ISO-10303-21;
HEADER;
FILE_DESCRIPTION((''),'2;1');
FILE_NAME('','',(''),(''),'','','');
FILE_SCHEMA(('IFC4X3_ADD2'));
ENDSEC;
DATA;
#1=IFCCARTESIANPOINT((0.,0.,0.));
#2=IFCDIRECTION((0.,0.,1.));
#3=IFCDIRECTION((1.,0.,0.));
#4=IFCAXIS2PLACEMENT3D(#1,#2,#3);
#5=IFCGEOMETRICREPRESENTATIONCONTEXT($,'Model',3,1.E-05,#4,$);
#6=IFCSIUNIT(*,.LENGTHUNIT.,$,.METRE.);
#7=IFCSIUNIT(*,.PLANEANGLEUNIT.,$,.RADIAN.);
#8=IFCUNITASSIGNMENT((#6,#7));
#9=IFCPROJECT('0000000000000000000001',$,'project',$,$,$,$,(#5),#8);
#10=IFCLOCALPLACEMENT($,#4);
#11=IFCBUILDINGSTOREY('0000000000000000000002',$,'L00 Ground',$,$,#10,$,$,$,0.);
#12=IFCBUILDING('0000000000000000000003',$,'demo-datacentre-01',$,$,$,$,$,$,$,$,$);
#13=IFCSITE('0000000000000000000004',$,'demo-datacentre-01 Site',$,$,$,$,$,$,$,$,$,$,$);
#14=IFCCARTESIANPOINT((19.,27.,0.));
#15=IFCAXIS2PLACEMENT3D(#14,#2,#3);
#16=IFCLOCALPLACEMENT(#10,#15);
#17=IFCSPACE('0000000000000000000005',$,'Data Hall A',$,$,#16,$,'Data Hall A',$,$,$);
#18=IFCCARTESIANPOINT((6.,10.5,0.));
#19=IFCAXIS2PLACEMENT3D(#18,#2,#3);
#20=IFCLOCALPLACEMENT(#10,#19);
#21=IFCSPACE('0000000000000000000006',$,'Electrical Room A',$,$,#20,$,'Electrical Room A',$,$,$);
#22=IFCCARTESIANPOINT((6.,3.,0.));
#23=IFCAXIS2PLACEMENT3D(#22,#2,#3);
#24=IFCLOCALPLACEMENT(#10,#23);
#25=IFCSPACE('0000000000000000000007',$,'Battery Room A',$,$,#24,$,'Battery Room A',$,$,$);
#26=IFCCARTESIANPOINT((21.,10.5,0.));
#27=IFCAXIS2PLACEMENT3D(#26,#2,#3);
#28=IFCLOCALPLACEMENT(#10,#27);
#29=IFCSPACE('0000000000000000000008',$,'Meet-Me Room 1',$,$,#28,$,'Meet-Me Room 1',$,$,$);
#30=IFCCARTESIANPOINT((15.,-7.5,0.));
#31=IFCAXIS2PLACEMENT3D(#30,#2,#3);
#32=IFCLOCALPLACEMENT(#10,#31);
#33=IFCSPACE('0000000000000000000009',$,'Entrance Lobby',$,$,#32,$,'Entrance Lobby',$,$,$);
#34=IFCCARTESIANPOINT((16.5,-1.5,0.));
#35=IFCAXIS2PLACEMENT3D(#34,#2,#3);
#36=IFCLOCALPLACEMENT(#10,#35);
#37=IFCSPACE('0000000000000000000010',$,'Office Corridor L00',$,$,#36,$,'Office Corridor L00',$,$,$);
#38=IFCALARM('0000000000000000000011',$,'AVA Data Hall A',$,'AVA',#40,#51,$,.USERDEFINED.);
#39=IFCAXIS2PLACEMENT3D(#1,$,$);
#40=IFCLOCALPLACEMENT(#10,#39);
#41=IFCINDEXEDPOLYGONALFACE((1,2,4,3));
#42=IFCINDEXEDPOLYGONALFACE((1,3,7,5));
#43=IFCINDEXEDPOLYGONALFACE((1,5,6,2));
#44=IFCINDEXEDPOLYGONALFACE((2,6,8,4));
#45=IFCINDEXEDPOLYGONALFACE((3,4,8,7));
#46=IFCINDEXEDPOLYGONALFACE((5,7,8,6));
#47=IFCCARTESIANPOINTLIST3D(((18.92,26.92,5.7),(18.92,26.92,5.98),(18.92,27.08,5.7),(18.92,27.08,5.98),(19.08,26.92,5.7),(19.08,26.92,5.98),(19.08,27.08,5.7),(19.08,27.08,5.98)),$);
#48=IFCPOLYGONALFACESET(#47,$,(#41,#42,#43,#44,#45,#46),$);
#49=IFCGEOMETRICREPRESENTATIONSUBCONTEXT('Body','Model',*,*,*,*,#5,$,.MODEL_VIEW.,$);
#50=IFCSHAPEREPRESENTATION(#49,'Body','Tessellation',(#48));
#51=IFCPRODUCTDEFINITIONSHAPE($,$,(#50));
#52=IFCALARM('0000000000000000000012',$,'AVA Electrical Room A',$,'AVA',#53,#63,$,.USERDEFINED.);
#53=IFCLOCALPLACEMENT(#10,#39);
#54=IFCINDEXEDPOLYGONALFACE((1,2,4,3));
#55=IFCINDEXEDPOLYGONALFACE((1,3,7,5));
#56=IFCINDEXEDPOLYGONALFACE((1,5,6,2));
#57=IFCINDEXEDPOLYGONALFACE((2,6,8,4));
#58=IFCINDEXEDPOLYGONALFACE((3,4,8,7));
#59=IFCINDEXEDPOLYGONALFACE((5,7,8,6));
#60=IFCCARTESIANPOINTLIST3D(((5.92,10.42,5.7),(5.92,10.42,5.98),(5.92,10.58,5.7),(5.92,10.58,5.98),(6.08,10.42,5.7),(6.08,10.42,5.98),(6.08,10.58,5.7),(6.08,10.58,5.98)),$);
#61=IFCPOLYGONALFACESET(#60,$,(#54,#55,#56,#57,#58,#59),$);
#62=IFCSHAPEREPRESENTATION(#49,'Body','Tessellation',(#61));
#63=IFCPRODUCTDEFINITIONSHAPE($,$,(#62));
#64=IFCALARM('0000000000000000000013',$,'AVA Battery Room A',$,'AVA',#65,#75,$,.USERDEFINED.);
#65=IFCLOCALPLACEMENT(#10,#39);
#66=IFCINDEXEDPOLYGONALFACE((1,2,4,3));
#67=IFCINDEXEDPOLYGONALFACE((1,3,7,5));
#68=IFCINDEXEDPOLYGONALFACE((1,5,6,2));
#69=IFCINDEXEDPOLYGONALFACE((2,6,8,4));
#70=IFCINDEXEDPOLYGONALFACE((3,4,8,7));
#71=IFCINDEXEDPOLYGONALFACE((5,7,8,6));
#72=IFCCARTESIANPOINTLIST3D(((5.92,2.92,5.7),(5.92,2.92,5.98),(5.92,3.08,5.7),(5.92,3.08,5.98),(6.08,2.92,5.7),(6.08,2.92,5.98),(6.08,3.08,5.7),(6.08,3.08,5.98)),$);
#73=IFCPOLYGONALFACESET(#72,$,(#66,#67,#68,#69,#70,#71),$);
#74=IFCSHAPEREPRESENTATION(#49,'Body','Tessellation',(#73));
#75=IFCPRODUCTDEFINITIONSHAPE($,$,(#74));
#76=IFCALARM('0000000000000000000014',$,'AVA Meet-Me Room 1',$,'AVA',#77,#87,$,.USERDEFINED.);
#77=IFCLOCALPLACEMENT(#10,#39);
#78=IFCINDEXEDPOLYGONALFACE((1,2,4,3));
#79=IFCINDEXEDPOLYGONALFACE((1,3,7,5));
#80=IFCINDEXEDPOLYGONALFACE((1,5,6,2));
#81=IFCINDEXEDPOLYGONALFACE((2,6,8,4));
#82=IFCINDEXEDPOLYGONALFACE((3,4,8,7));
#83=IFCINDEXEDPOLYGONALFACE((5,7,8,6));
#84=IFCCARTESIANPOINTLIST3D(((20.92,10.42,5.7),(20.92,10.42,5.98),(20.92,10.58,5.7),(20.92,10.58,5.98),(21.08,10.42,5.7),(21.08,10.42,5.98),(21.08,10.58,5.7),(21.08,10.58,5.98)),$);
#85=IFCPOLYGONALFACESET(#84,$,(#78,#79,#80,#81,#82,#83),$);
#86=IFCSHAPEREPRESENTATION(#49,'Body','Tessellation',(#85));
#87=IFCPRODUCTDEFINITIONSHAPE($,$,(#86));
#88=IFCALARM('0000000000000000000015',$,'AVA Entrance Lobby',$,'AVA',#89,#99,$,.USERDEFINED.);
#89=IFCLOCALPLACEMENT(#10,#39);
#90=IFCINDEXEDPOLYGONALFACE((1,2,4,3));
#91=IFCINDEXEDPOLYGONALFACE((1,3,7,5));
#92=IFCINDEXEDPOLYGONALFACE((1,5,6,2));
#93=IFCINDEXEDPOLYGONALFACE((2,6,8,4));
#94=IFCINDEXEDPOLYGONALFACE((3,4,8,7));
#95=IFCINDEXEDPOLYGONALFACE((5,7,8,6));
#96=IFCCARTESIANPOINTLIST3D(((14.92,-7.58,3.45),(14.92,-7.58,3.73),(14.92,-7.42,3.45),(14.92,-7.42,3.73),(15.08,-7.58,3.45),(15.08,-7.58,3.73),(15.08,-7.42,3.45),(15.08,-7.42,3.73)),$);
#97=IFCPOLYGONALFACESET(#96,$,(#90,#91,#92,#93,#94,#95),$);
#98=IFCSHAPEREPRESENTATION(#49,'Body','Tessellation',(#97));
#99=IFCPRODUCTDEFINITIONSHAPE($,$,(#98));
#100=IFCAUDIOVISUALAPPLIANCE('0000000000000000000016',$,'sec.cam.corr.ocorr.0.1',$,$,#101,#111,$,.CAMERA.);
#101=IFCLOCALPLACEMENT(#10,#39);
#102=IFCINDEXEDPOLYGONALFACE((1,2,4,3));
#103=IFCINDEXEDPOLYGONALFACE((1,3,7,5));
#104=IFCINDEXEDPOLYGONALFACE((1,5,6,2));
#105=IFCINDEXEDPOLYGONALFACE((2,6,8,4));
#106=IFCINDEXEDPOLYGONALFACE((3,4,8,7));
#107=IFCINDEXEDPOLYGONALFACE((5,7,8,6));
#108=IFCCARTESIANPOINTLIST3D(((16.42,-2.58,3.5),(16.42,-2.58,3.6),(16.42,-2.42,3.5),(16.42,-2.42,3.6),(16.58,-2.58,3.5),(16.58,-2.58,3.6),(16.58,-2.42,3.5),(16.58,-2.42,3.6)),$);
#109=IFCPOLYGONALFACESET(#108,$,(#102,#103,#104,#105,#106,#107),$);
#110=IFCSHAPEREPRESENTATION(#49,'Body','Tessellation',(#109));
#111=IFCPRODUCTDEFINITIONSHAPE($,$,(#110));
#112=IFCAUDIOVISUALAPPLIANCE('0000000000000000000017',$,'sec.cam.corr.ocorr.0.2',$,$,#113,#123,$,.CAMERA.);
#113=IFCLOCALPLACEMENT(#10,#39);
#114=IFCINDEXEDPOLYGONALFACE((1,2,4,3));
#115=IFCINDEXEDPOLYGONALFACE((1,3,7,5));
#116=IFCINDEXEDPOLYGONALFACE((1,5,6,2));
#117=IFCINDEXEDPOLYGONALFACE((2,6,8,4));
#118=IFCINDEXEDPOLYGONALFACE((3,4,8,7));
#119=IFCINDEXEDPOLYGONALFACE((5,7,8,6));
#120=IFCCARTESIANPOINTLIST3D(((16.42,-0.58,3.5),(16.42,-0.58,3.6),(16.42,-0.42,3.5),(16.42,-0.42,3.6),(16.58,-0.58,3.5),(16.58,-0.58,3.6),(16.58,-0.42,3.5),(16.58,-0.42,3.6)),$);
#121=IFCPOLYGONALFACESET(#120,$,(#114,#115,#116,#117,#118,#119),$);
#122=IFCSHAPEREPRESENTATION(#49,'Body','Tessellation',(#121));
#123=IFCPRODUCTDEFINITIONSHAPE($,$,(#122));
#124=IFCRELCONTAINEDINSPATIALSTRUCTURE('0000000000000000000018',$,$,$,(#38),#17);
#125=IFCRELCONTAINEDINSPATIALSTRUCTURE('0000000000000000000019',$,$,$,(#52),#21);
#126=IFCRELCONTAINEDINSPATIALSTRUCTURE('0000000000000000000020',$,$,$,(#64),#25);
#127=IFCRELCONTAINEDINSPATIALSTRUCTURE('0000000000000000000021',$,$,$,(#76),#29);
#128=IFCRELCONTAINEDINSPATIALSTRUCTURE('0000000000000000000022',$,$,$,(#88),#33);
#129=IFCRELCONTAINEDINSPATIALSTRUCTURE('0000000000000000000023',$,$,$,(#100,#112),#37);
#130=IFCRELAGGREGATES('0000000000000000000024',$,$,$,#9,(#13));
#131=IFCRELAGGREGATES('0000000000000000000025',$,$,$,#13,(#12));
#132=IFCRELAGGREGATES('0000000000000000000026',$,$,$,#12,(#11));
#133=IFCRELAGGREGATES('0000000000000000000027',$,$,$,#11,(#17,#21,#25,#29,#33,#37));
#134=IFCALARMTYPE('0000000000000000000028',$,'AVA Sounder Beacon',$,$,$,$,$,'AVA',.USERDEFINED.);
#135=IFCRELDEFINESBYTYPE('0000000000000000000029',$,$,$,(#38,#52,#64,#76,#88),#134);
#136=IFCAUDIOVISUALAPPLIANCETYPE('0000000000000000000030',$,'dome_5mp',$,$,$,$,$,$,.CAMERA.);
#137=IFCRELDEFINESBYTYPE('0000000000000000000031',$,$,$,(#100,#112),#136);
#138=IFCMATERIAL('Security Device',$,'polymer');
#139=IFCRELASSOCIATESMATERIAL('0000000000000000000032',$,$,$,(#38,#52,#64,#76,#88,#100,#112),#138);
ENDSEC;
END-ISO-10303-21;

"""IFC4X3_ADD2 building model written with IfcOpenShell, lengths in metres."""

from ifc_helpers import new_model, si_unit, frame, origin_with_axes, place, context, subcontext, project, spatial, rectangle, extrude, source, transform, mapped, material, type_object, type_shapes, element, save


model = new_model("IFC4X3_ADD2")

# Units and contexts
model_context = context("Model", 3, precision=1e-05, world=origin_with_axes())
body_context = subcontext(model_context, "Body", "Model", "MODEL_VIEW")
ifc_project = project(units=[si_unit("LENGTHUNIT", "METRE"), si_unit("PLANEANGLEUNIT", "RADIAN")], contexts=[model_context])

# Site, building, storey, space
site = spatial("IfcSite", under=ifc_project, Name="demo-datacentre-01 Site")
building = spatial("IfcBuilding", under=site, Name="demo-datacentre-01")
storey_placement = place(None, origin_with_axes())
storey = spatial("IfcBuildingStorey", under=building, at=storey_placement, Name="L00 Ground", Elevation=0.0)
space_1_placement = place(storey_placement, frame((19.0, 27.0, 0.0), z_axis=(0.0, 0.0, 1.0), x_axis=(1.0, 0.0, 0.0)))
space_1 = spatial("IfcSpace", under=storey, at=space_1_placement, Name="Data Hall A", LongName="Data Hall A")

# Alarm
ifc_material = material(Name="Security Device", Category="polymer")
alarm_type = type_object("IfcAlarmType", Name="AVA Sounder Beacon", ElementType="AVA", PredefinedType="USERDEFINED")
alarm_1_placement = place(space_1_placement, frame((0.0, 0.0, 5.7), z_axis=(0.0, 0.0, 1.0), x_axis=(1.0, 0.0, 0.0)))
element("IfcAlarm", 1, at=alarm_1_placement, inside=space_1, type_object=alarm_type, material=ifc_material, Name="AVA Data Hall A", ObjectType="AVA", PredefinedType="USERDEFINED", context=body_context, shape_type="SweptSolid", body=[
    extrude(rectangle(XDim=0.16, YDim=0.16), origin_with_axes(), (0.0, 0.0, 1.0), 0.28),
])

# Shared definitions
space_2_placement = place(storey_placement, frame((6.0, 10.5, 0.0), z_axis=(0.0, 0.0, 1.0), x_axis=(1.0, 0.0, 0.0)))
space_2 = spatial("IfcSpace", under=storey, at=space_2_placement, Name="Electrical Room A", LongName="Electrical Room A")

# Alarm
alarm_2_placement = place(space_2_placement, frame((0.0, 0.0, 5.7), z_axis=(0.0, 0.0, 1.0), x_axis=(1.0, 0.0, 0.0)))
element("IfcAlarm", 2, at=alarm_2_placement, inside=space_2, type_object=alarm_type, material=ifc_material, Name="AVA Electrical Room A", ObjectType="AVA", PredefinedType="USERDEFINED", context=body_context, shape_type="SweptSolid", body=[
    extrude(rectangle(XDim=0.16, YDim=0.16), origin_with_axes(), (0.0, 0.0, 1.0), 0.28),
])

# Shared definitions
space_3_placement = place(storey_placement, frame((6.0, 3.0, 0.0), z_axis=(0.0, 0.0, 1.0), x_axis=(1.0, 0.0, 0.0)))
space_3 = spatial("IfcSpace", under=storey, at=space_3_placement, Name="Battery Room A", LongName="Battery Room A")

# Alarm
alarm_3_placement = place(space_3_placement, frame((0.0, 0.0, 5.7), z_axis=(0.0, 0.0, 1.0), x_axis=(1.0, 0.0, 0.0)))
element("IfcAlarm", 3, at=alarm_3_placement, inside=space_3, type_object=alarm_type, material=ifc_material, Name="AVA Battery Room A", ObjectType="AVA", PredefinedType="USERDEFINED", context=body_context, shape_type="SweptSolid", body=[
    extrude(rectangle(XDim=0.16, YDim=0.16), origin_with_axes(), (0.0, 0.0, 1.0), 0.28),
])

# Shared definitions
space_4_placement = place(storey_placement, frame((21.0, 10.5, 0.0), z_axis=(0.0, 0.0, 1.0), x_axis=(1.0, 0.0, 0.0)))
space_4 = spatial("IfcSpace", under=storey, at=space_4_placement, Name="Meet-Me Room 1", LongName="Meet-Me Room 1")

# Alarm
alarm_4_placement = place(space_4_placement, frame((0.0, 0.0, 5.7), z_axis=(0.0, 0.0, 1.0), x_axis=(1.0, 0.0, 0.0)))
element("IfcAlarm", 4, at=alarm_4_placement, inside=space_4, type_object=alarm_type, material=ifc_material, Name="AVA Meet-Me Room 1", ObjectType="AVA", PredefinedType="USERDEFINED", context=body_context, shape_type="SweptSolid", body=[
    extrude(rectangle(XDim=0.16, YDim=0.16), origin_with_axes(), (0.0, 0.0, 1.0), 0.28),
])

# Shared definitions
space_5_placement = place(storey_placement, frame((15.0, -7.5, 0.0), z_axis=(0.0, 0.0, 1.0), x_axis=(1.0, 0.0, 0.0)))
space_5 = spatial("IfcSpace", under=storey, at=space_5_placement, Name="Entrance Lobby", LongName="Entrance Lobby")

# Alarm
alarm_5_placement = place(space_5_placement, frame((0.0, 0.0, 3.45), z_axis=(0.0, 0.0, 1.0), x_axis=(1.0, 0.0, 0.0)))
element("IfcAlarm", 5, at=alarm_5_placement, inside=space_5, type_object=alarm_type, material=ifc_material, Name="AVA Entrance Lobby", ObjectType="AVA", PredefinedType="USERDEFINED", context=body_context, shape_type="SweptSolid", body=[
    extrude(rectangle(XDim=0.16, YDim=0.16), origin_with_axes(), (0.0, 0.0, 1.0), 0.28),
])

# Shared definitions
audio_visual_appliance_type_1 = type_object("IfcAudioVisualApplianceType", Name="dome_5mp", PredefinedType="CAMERA")
shared_shape_1 = source(origin_with_axes(), body_context, "Body", "SweptSolid", [
    extrude(rectangle(XDim=0.16, YDim=0.16), origin_with_axes(), (0.0, 0.0, 1.0), 0.1),
])
type_shapes(audio_visual_appliance_type_1, [shared_shape_1])

# Shared definitions
space_6_placement = place(storey_placement, frame((16.5, -1.5, 0.0), z_axis=(0.0, 0.0, 1.0), x_axis=(1.0, 0.0, 0.0)))
space_6 = spatial("IfcSpace", under=storey, at=space_6_placement, Name="Office Corridor L00", LongName="Office Corridor L00")

# Audio visual appliances
for number, where, z_axis, x_axis, name in (
    (6, (0.0, -1.0, 3.5), (0.0, 0.0, 1.0), (1.0, 0.0, 0.0), "sec.cam.corr.ocorr.0.1"),
    (7, (0.0, 1.0, 3.5), (0.0, 0.0, 1.0), (1.0, 0.0, 0.0), "sec.cam.corr.ocorr.0.2"),
):
    element("IfcAudioVisualAppliance", number, at=place(space_6_placement, frame(where, z_axis=z_axis, x_axis=x_axis)), inside=space_6, type_object=audio_visual_appliance_type_1, material=ifc_material, Name=name, PredefinedType="CAMERA", context=body_context, shape_type="MappedRepresentation", body=[
        mapped(shared_shape_1, transform((0.0, 0.0, 0.0), x_axis=(1.0, 0.0, 0.0), y_axis=(0.0, 1.0, 0.0), z_axis=(0.0, 0.0, 1.0), scale=1.0)),
    ])

save(model, "model.ifc")
